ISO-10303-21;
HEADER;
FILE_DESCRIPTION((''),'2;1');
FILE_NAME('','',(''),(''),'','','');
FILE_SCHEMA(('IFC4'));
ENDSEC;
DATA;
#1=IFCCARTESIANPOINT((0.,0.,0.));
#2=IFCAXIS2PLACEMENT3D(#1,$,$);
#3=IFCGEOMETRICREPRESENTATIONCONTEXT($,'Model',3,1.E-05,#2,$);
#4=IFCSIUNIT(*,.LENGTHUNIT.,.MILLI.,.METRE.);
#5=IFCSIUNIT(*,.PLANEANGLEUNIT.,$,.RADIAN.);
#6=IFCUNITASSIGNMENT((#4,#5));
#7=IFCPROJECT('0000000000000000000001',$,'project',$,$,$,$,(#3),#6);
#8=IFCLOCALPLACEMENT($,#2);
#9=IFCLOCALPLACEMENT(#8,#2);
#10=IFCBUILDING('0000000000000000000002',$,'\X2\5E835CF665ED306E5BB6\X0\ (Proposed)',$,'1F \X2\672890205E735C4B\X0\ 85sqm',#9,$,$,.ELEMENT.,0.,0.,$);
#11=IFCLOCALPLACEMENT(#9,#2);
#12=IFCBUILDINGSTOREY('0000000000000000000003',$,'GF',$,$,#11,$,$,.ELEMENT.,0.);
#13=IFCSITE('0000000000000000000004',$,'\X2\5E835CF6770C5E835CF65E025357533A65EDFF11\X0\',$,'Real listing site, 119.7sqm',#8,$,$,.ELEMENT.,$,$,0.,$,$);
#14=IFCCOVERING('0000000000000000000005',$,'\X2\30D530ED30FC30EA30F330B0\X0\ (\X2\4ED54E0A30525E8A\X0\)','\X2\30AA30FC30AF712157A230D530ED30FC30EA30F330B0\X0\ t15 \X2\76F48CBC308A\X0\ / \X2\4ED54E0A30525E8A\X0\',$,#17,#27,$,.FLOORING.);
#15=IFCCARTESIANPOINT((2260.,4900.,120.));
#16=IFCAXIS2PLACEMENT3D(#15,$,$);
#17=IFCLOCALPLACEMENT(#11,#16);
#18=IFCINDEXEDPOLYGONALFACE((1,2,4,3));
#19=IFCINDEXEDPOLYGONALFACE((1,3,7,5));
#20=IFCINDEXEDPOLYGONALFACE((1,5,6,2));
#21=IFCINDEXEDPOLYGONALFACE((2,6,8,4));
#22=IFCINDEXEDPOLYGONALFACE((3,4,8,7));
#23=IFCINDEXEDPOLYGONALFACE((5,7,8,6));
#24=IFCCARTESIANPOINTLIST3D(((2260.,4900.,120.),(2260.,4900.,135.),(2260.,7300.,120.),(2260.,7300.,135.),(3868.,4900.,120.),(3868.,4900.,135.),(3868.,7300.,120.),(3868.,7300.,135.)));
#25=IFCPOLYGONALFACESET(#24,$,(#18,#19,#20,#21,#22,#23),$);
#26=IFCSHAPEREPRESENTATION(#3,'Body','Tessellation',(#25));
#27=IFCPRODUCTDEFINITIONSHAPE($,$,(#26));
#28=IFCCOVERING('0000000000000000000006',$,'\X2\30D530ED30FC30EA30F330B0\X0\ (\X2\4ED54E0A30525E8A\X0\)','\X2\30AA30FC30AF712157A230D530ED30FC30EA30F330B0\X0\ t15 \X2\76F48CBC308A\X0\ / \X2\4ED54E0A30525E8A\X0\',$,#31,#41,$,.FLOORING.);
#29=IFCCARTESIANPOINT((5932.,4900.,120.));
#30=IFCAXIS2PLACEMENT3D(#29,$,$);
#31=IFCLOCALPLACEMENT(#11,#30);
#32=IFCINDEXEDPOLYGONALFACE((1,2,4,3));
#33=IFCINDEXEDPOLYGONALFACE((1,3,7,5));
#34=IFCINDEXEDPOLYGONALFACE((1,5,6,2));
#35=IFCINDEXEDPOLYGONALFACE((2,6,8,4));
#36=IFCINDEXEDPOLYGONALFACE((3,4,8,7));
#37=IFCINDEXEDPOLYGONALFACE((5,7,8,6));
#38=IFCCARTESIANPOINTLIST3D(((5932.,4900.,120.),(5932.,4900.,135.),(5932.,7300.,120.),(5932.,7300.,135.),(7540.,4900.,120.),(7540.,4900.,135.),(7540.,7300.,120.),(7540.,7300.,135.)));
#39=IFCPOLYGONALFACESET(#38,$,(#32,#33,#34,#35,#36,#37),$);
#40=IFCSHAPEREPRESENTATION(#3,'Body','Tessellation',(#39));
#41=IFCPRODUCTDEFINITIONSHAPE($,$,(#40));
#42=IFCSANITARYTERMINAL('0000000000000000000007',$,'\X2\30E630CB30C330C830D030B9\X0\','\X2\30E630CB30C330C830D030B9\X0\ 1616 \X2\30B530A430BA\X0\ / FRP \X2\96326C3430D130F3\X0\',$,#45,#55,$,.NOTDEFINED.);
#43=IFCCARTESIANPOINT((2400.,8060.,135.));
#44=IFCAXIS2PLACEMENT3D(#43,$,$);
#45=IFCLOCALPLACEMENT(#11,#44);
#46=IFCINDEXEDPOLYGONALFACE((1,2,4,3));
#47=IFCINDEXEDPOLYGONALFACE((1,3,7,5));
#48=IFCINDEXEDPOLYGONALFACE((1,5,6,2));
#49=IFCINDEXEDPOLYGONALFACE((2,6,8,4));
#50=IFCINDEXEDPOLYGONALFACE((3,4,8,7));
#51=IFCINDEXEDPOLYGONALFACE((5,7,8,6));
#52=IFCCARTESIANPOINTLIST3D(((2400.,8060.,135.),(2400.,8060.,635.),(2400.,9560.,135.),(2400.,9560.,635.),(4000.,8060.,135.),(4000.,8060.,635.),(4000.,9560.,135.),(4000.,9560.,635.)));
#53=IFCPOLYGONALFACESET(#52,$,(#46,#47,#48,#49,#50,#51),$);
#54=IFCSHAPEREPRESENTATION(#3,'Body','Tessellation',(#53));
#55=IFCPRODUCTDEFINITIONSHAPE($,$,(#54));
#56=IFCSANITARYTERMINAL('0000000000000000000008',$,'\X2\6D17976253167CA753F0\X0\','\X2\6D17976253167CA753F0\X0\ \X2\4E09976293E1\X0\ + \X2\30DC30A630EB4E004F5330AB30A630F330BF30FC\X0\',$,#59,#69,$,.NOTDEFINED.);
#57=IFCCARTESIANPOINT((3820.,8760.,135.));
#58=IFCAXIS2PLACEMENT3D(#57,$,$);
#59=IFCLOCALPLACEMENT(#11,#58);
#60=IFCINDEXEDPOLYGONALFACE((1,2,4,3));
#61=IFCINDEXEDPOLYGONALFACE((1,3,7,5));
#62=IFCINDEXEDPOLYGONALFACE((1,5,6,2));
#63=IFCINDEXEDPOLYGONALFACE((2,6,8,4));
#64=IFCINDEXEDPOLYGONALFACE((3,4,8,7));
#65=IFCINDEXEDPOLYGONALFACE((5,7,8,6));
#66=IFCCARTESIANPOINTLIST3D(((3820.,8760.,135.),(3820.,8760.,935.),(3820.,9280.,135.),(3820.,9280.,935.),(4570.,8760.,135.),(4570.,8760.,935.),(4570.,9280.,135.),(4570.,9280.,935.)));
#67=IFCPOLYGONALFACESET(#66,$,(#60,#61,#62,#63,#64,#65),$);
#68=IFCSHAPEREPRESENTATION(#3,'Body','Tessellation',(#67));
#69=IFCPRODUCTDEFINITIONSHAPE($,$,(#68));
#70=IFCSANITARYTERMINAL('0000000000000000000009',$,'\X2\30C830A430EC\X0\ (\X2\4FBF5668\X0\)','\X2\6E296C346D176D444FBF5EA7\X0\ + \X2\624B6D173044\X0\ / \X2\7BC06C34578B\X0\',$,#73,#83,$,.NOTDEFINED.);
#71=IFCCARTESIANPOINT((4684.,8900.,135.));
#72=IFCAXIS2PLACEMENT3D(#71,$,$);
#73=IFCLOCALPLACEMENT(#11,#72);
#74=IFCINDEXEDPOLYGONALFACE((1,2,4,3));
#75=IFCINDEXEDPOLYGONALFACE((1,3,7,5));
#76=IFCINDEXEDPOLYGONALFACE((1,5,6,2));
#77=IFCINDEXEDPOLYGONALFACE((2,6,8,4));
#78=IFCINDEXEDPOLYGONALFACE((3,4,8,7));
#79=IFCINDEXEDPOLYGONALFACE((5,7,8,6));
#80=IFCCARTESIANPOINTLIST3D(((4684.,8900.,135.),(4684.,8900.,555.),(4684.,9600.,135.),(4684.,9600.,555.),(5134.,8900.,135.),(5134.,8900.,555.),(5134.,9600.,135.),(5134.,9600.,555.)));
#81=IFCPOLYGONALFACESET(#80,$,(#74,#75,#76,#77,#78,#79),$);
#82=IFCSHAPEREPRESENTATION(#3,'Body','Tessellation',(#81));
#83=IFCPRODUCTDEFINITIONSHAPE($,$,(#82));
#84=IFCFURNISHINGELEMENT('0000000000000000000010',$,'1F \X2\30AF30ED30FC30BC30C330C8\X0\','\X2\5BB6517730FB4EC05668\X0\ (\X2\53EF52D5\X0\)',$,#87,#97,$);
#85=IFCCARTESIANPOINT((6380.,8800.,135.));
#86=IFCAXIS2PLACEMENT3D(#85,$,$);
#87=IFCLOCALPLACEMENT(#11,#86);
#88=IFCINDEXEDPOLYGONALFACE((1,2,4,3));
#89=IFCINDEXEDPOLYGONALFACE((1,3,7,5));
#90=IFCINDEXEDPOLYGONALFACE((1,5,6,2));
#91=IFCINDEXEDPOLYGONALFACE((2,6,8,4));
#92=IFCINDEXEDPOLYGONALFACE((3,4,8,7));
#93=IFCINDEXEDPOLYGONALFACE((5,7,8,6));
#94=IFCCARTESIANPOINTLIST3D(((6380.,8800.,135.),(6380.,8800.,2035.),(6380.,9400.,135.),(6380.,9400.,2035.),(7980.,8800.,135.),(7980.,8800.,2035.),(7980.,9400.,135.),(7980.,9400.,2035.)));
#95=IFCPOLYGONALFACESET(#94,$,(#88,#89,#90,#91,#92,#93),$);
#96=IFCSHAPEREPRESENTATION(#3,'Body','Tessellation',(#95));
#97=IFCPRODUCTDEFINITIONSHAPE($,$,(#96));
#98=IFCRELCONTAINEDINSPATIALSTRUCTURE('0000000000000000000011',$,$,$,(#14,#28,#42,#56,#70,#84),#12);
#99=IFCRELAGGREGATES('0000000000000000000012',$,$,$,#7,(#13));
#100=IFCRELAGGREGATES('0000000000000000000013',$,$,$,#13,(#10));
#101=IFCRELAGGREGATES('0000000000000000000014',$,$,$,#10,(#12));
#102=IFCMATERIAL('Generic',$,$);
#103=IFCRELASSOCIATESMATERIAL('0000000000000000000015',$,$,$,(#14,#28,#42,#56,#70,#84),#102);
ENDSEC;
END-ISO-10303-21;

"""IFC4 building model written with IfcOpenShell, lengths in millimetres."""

from ifc_helpers import new_model, si_unit, frame, frame_2d, origin, place, context, project, spatial, rectangle, extrude, material, element, save


model = new_model("IFC4")

# Units and contexts
model_context = context("Model", 3, precision=1e-05, world=origin())
ifc_project = project(units=[si_unit("LENGTHUNIT", "METRE", prefix="MILLI"), si_unit("PLANEANGLEUNIT", "RADIAN")], contexts=[model_context])

# Site, building, storey
site_placement = place(None, origin())
site = spatial("IfcSite", under=ifc_project, at=site_placement, Name="広島県広島市南区旭１", ObjectType="Real listing site, 119.7sqm", CompositionType="ELEMENT", RefElevation=0.0)
building_placement = place(site_placement, origin())
building = spatial("IfcBuilding", under=site, at=building_placement, Name="広島旭の家 (Proposed)", ObjectType="1F 木造平屋 85sqm", CompositionType="ELEMENT", ElevationOfRefHeight=0.0, ElevationOfTerrain=0.0)
storey_placement = place(building_placement, origin())
storey = spatial("IfcBuildingStorey", under=building, at=storey_placement, Name="GF", CompositionType="ELEMENT", Elevation=0.0)

# Coverings
ifc_material_1 = material(Name="Generic")
covering_1_placement = place(storey_placement, frame((2260.0, 4900.0, 120.0)))
element("IfcCovering", 1, at=covering_1_placement, inside=storey, material=ifc_material_1, Name="フローリング (仕上げ床)", Description="オーク無垢フローリング t15 直貼り / 仕上げ床", PredefinedType="FLOORING", context=model_context, shape_type="SweptSolid", body=[
    extrude(rectangle(XDim=1608.0, YDim=2400.0, at=frame_2d((804.0, 1200.0))), frame((2260.0, 4900.0, 120.0)), (0.0, 0.0, 1.0), 15.0),
])
covering_2_placement = place(storey_placement, frame((5932.0, 4900.0, 120.0)))
element("IfcCovering", 2, at=covering_2_placement, inside=storey, material=ifc_material_1, Name="フローリング (仕上げ床)", Description="オーク無垢フローリング t15 直貼り / 仕上げ床", PredefinedType="FLOORING", context=model_context, shape_type="SweptSolid", body=[
    extrude(rectangle(XDim=1608.0, YDim=2400.0, at=frame_2d((804.0, 1200.0))), frame((5932.0, 4900.0, 120.0)), (0.0, 0.0, 1.0), 15.0),
])

# Sanitary terminals
sanitary_terminal_1_placement = place(storey_placement, frame((2400.0, 8060.0, 135.0)))
element("IfcSanitaryTerminal", 3, at=sanitary_terminal_1_placement, inside=storey, material=ifc_material_1, Name="ユニットバス", Description="ユニットバス 1616 サイズ / FRP 防水パン", PredefinedType="NOTDEFINED", context=model_context, shape_type="SweptSolid", body=[
    extrude(rectangle(XDim=1600.0, YDim=1500.0, at=frame_2d((800.0, 750.0))), frame((2400.0, 8060.0, 135.0)), (0.0, 0.0, 1.0), 500.0),
])
sanitary_terminal_2_placement = place(storey_placement, frame((3820.0, 8760.0, 135.0)))
element("IfcSanitaryTerminal", 4, at=sanitary_terminal_2_placement, inside=storey, material=ifc_material_1, Name="洗面化粧台", Description="洗面化粧台 三面鏡 + ボウル一体カウンター", PredefinedType="NOTDEFINED", context=model_context, shape_type="SweptSolid", body=[
    extrude(rectangle(XDim=750.0, YDim=520.0, at=frame_2d((375.0, 260.0))), frame((3820.0, 8760.0, 135.0)), (0.0, 0.0, 1.0), 800.0),
])
sanitary_terminal_3_placement = place(storey_placement, frame((4684.0, 8900.0, 135.0)))
element("IfcSanitaryTerminal", 5, at=sanitary_terminal_3_placement, inside=storey, material=ifc_material_1, Name="トイレ (便器)", Description="温水洗浄便座 + 手洗い / 節水型", PredefinedType="NOTDEFINED", context=model_context, shape_type="SweptSolid", body=[
    extrude(rectangle(XDim=450.0, YDim=700.0, at=frame_2d((225.0, 350.0))), frame((4684.0, 8900.0, 135.0)), (0.0, 0.0, 1.0), 420.0),
])

# Furnishing element
furnishing_placement = place(storey_placement, frame((6380.0, 8800.0, 135.0)))
element("IfcFurnishingElement", 6, at=furnishing_placement, inside=storey, material=ifc_material_1, Name="1F クローゼット", Description="家具・什器 (可動)", context=model_context, shape_type="SweptSolid", body=[
    extrude(rectangle(XDim=1600.0, YDim=600.0, at=frame_2d((800.0, 300.0))), frame((6380.0, 8800.0, 135.0)), (0.0, 0.0, 1.0), 1900.0),
])

save(model, "model.ifc")
